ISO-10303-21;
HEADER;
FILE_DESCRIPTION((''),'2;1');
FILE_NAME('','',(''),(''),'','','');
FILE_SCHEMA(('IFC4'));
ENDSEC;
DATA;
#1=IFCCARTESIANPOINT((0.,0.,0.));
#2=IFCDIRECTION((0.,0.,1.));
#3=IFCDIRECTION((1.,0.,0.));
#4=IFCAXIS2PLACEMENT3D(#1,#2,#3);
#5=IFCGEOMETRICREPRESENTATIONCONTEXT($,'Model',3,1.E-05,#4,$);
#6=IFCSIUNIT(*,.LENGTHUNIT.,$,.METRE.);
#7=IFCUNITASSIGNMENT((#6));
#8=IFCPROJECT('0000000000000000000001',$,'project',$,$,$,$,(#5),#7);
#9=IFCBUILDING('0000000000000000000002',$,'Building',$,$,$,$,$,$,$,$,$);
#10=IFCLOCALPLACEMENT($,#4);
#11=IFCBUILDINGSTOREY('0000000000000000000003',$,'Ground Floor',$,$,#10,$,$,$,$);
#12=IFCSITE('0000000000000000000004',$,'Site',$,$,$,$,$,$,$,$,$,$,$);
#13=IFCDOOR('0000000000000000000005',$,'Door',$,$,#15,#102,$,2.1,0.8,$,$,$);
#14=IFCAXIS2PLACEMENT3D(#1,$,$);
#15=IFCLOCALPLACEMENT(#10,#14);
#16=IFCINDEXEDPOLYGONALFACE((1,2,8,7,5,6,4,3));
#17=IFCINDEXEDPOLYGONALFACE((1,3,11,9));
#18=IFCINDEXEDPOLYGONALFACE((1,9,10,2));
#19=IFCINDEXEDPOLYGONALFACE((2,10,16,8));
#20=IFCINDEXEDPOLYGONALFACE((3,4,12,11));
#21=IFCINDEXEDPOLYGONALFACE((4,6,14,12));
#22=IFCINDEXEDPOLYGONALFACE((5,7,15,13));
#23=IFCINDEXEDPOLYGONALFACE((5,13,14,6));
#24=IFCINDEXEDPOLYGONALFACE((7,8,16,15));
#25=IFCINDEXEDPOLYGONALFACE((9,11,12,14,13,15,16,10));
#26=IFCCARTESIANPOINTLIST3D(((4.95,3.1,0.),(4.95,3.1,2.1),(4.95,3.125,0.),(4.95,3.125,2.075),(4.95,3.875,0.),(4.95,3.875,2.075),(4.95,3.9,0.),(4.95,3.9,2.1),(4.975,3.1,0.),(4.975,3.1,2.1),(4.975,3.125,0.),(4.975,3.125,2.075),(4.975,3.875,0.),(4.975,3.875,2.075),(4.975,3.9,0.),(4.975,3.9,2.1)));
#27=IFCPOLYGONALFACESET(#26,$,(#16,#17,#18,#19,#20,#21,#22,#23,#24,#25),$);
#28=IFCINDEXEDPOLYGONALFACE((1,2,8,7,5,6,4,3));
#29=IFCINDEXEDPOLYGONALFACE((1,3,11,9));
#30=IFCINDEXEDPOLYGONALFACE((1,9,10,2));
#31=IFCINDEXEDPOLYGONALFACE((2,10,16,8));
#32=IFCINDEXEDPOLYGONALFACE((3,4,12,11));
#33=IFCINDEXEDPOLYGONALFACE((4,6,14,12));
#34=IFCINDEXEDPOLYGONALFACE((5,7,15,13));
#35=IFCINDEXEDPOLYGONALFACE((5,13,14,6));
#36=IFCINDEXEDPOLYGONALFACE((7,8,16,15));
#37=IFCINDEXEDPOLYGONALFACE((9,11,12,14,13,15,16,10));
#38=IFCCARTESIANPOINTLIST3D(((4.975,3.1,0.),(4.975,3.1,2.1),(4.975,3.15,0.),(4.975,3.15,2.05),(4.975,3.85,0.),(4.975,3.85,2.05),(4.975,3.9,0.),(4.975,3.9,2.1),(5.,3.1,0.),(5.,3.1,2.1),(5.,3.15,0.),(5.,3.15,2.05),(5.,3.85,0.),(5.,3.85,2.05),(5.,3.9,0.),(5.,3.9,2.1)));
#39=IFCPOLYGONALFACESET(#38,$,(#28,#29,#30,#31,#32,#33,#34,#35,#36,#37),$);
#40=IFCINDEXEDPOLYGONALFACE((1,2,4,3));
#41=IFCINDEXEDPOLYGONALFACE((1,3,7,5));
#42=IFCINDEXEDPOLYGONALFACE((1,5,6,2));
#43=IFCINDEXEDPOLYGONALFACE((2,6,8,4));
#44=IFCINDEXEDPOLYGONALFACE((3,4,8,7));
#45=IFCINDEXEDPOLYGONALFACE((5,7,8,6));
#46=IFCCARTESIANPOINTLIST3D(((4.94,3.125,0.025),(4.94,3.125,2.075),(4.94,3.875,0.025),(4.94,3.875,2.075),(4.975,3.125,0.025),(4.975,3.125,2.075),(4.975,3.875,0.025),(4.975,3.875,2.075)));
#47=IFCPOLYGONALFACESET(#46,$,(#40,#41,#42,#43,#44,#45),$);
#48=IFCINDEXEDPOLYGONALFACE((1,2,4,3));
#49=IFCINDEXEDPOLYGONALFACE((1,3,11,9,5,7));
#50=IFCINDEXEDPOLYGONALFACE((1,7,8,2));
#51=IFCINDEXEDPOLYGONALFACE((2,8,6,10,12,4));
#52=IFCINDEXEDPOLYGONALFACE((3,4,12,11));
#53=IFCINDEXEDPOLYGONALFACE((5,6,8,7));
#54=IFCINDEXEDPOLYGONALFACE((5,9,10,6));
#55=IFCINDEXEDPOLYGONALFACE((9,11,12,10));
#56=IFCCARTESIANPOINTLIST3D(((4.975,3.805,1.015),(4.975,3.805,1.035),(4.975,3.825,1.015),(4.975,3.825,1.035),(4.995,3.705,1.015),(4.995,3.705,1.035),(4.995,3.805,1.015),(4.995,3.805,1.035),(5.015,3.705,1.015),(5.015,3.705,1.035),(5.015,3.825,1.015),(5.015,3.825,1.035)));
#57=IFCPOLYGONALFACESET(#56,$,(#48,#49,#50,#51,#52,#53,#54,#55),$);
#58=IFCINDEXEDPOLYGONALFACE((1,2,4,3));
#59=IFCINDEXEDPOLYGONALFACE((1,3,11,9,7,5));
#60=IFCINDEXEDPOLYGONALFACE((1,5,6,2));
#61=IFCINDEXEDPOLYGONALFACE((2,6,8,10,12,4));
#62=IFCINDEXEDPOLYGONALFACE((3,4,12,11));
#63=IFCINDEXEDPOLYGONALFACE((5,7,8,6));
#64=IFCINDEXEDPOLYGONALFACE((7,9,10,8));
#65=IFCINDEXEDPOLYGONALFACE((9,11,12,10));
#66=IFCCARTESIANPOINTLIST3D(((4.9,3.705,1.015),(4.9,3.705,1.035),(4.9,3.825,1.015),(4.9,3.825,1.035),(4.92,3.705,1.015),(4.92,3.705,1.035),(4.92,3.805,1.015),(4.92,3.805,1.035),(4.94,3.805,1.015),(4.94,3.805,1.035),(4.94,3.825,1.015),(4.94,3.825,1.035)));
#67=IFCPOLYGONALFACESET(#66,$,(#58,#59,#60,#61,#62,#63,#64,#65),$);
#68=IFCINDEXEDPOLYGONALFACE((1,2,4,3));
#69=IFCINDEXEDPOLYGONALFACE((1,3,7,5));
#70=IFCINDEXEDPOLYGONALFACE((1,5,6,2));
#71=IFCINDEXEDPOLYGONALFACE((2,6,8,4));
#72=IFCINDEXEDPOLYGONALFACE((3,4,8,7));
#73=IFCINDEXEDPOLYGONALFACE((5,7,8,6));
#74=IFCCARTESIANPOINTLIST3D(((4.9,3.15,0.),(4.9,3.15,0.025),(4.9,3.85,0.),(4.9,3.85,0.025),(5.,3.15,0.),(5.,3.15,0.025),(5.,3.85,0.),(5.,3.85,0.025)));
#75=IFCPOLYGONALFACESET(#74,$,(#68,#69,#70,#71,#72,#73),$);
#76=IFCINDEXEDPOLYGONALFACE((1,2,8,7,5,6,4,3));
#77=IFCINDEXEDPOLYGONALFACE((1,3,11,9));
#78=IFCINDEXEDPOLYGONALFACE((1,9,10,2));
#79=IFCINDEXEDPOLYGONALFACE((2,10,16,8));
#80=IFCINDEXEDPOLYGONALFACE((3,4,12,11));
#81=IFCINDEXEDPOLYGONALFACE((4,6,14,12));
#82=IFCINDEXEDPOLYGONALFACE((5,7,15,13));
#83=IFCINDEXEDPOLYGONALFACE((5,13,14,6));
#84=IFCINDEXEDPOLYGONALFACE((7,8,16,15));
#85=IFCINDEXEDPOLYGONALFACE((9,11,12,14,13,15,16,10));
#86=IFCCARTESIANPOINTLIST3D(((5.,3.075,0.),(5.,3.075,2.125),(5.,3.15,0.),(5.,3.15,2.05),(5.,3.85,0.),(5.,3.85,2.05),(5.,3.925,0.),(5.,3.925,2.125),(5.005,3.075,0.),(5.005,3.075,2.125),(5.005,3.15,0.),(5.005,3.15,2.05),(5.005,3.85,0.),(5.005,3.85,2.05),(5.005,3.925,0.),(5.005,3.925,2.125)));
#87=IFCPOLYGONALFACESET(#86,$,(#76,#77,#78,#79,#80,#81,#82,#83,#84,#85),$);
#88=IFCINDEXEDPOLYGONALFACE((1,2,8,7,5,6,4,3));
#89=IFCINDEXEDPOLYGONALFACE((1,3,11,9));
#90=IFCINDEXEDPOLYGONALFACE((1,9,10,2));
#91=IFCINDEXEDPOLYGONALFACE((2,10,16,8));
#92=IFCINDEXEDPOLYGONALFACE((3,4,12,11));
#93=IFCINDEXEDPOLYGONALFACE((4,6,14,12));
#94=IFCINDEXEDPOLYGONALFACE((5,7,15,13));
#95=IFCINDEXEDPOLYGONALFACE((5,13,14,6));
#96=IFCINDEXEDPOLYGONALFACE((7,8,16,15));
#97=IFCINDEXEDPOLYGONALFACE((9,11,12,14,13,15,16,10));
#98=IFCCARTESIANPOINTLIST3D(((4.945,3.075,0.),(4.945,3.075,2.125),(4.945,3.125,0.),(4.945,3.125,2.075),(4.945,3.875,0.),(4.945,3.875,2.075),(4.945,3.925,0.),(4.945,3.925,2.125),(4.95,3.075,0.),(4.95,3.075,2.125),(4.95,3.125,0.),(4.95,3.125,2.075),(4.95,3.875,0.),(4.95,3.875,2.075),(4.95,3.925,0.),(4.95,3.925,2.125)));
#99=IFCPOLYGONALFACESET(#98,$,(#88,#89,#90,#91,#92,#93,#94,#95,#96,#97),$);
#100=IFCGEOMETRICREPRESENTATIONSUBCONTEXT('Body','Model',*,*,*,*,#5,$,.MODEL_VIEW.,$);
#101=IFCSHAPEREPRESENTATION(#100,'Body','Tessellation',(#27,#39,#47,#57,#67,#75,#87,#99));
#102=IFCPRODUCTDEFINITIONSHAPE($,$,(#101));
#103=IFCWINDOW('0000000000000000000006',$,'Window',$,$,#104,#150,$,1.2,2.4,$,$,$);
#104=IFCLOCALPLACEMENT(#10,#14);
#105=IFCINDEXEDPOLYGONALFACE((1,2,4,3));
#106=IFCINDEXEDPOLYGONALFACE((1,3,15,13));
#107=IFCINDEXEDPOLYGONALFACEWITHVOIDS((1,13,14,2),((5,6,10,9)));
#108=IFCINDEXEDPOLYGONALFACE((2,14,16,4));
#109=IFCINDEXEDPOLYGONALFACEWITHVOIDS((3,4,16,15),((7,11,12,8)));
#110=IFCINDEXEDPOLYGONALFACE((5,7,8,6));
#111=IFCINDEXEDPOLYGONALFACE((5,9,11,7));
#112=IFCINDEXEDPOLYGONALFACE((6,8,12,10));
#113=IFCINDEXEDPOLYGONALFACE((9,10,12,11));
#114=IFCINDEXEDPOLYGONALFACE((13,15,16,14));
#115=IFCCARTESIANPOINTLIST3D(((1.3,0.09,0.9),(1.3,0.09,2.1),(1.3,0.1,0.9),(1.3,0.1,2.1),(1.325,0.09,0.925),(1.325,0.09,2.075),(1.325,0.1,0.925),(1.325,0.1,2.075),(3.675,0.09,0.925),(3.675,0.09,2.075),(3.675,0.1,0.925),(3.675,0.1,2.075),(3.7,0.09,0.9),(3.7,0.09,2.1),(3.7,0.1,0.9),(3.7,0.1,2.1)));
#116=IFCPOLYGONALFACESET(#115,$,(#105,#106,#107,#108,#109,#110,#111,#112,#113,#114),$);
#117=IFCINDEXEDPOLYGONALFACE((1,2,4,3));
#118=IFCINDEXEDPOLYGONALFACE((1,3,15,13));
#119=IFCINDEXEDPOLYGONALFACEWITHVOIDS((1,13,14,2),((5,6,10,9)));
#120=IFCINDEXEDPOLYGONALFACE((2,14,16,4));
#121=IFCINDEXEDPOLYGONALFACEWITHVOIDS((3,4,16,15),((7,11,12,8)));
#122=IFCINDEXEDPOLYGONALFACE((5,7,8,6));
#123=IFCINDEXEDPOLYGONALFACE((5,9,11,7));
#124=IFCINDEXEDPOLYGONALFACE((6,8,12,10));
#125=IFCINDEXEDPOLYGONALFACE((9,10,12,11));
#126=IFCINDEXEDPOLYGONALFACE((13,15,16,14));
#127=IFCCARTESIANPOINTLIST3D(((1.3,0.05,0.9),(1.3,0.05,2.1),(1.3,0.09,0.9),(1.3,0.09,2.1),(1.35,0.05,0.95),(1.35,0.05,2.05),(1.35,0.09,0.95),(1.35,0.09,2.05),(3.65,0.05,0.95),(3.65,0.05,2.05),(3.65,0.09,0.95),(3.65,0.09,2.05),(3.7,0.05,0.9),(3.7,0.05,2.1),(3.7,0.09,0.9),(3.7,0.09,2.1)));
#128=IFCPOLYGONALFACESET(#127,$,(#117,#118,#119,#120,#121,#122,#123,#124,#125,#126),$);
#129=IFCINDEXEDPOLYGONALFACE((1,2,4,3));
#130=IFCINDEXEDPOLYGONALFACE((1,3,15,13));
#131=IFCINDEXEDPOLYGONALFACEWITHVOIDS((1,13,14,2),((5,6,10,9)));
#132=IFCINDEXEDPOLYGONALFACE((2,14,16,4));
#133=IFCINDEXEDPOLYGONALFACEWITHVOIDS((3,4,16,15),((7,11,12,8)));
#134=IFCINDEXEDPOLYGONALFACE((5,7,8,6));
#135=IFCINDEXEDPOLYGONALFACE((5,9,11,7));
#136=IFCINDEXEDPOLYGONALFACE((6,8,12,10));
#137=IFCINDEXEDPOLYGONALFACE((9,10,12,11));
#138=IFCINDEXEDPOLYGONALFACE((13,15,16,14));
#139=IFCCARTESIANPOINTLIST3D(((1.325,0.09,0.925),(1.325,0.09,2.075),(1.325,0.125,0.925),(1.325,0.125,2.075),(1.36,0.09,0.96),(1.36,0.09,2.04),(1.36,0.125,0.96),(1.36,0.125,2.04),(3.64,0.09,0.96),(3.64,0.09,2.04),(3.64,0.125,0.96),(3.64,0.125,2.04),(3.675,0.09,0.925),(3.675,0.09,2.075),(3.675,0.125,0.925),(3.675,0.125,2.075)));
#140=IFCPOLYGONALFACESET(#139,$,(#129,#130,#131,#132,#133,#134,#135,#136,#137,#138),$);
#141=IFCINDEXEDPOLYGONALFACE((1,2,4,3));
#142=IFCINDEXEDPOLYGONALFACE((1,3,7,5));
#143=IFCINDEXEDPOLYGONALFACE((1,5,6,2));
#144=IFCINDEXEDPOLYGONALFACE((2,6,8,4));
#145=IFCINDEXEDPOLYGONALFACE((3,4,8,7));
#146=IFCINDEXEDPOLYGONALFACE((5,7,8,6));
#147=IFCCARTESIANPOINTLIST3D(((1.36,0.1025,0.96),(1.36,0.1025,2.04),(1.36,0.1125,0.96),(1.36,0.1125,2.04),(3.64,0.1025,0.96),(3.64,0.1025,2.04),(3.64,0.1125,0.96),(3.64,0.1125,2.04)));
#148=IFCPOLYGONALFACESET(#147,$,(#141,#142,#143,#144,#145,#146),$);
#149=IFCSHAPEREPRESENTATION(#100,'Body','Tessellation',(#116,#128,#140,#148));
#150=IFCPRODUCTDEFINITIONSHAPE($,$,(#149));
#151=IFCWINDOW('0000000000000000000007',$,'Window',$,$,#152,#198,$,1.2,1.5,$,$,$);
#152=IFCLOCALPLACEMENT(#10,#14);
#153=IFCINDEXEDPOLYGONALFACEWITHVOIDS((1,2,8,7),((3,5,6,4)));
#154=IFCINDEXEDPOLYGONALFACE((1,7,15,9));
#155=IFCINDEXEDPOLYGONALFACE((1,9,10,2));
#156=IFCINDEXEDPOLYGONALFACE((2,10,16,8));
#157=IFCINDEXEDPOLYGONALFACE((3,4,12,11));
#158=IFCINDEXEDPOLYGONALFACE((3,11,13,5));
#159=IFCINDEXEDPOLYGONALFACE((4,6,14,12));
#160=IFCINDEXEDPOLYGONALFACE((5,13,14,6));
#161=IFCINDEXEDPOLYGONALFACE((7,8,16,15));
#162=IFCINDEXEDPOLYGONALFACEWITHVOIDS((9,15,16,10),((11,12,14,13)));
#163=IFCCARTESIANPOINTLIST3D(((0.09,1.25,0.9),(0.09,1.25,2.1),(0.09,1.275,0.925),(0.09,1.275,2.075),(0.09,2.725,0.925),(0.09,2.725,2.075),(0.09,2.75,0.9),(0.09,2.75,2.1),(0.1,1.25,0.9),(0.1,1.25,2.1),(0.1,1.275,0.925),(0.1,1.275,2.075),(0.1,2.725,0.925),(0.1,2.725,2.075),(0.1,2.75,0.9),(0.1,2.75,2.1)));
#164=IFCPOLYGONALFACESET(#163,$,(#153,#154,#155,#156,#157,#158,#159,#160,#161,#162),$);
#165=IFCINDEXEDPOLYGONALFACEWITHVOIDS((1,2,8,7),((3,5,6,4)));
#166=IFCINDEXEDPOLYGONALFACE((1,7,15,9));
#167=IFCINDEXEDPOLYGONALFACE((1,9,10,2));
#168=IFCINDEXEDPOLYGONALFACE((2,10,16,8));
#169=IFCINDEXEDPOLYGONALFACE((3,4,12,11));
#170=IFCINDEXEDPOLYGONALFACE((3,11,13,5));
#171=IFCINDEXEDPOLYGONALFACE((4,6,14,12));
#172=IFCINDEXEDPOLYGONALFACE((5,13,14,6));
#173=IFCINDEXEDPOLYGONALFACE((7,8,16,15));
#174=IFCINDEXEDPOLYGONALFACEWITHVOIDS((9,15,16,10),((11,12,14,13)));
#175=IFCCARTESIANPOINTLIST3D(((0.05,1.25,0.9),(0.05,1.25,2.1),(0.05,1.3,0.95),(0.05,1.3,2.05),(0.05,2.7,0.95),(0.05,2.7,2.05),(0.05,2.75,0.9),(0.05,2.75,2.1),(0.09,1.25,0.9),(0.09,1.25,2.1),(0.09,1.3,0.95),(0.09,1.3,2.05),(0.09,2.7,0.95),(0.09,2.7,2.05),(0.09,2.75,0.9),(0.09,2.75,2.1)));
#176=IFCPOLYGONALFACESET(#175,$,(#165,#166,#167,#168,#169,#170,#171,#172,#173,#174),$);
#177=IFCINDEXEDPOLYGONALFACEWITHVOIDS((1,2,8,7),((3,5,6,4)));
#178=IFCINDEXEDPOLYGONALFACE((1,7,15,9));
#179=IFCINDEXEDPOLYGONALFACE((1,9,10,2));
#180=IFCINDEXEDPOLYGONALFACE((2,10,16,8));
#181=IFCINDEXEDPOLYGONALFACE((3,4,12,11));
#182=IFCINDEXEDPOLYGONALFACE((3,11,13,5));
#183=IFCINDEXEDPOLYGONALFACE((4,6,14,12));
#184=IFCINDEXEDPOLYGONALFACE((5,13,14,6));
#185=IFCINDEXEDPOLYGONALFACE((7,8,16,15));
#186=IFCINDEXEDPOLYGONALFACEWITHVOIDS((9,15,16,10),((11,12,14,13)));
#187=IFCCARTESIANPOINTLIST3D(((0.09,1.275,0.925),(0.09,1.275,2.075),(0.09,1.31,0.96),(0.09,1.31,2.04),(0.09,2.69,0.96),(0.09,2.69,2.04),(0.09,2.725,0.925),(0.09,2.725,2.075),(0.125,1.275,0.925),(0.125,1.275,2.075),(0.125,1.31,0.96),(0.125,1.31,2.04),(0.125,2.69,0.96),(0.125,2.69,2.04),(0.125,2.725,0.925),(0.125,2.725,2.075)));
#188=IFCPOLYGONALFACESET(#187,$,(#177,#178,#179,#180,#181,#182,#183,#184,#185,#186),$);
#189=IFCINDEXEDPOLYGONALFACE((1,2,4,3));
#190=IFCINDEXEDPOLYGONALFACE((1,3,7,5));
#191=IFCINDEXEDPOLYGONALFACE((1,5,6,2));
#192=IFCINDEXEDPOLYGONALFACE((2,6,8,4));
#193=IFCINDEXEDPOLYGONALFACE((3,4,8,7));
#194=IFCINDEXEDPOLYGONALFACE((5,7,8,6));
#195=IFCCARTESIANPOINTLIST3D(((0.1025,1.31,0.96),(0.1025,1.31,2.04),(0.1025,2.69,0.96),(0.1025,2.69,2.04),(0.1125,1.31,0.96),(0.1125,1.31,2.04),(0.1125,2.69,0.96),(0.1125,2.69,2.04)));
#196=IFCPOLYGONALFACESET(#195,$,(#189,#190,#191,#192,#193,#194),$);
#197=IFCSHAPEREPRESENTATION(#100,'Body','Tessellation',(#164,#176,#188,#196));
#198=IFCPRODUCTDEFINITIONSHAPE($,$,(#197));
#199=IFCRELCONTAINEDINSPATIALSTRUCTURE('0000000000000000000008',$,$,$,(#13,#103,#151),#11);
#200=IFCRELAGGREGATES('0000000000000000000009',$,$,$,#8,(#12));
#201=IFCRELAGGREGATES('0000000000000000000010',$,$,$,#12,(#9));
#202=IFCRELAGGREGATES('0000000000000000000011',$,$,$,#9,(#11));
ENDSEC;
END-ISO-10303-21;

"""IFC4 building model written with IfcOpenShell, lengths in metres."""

from ifc_helpers import new_model, si_unit, frame, origin_with_axes, place, context, subcontext, project, spatial, line, indexed_curve, outline, extrude, element, save


model = new_model("IFC4")

# Units and contexts
model_context = context("Model", 3, precision=1e-05, world=origin_with_axes())
body_context = subcontext(model_context, "Body", "Model", "MODEL_VIEW")
ifc_project = project(units=[si_unit("LENGTHUNIT", "METRE")], contexts=[model_context])

# Site, building, storey
site = spatial("IfcSite", under=ifc_project, Name="Site")
building = spatial("IfcBuilding", under=site, Name="Building")
storey_placement = place(None, origin_with_axes())
storey = spatial("IfcBuildingStorey", under=building, at=storey_placement, Name="Ground Floor")

# Door
door_1_placement = place(storey_placement, frame((5.0, 3.1, 0.0), z_axis=(0.0, 0.0, 1.0), x_axis=(0.0, 1.0, 0.0)))
element("IfcDoor", 1, at=door_1_placement, inside=storey, Name="Door", OverallHeight=2.1, OverallWidth=0.8, context=body_context, shape_type="SweptSolid", body=[
    extrude(outline(indexed_curve([(0.0, 0.0), (0.0, 2.1), (0.8, 2.1), (0.8, 0.0), (0.775, 0.0), (0.775, 2.075), (0.025, 2.075), (0.025, 0.0)], segments=[line(1, 2, 3, 4, 5, 6, 7, 8, 1)])), frame((0.0, 0.025, 0.0), z_axis=(0.0, -1.0, 0.0), x_axis=(1.0, 0.0, 0.0)), (0.0, 0.0, -1.0), 0.025),
    extrude(outline(indexed_curve([(0.0, 0.0), (0.0, 2.1), (0.8, 2.1), (0.8, 0.0), (0.75, 0.0), (0.75, 2.05), (0.05, 2.05), (0.05, 0.0)], segments=[line(1, 2, 3, 4, 5, 6, 7, 8, 1)])), frame((0.0, 0.0, 0.0), z_axis=(0.0, -1.0, 0.0), x_axis=(1.0, 0.0, 0.0)), (0.0, 0.0, -1.0), 0.025),
    extrude(outline(indexed_curve([(0.0, 0.0), (0.75, 0.0), (0.75, 0.035), (0.0, 0.035)], segments=[line(1, 2, 3, 4, 1)])), frame((0.025, 0.025, 0.025), z_axis=(0.0, 0.0, 1.0), x_axis=(1.0, 0.0, 0.0)), (0.0, 0.0, 1.0), 2.05),
    extrude(outline(indexed_curve([(0.0, 0.0), (0.0, -0.04), (-0.12, -0.04), (-0.12, -0.02), (-0.02, -0.02), (-0.02, 0.0)], segments=[line(1, 2, 3, 4, 5, 6, 1)])), frame((0.725, 0.025, 1.015), z_axis=(0.0, 0.0, 1.0), x_axis=(1.0, 0.0, 0.0)), (0.0, 0.0, 1.0), 0.02),
    extrude(outline(indexed_curve([(0.0, 0.0), (0.0, 0.04), (-0.12, 0.04), (-0.12, 0.02), (-0.02, 0.02), (-0.02, 0.0)], segments=[line(1, 2, 3, 4, 5, 6, 1)])), frame((0.725, 0.06, 1.015), z_axis=(0.0, 0.0, 1.0), x_axis=(1.0, 0.0, 0.0)), (0.0, 0.0, 1.0), 0.02),
    extrude(outline(indexed_curve([(0.0, 0.0), (0.7, 0.0), (0.7, 0.1), (0.0, 0.1)], segments=[line(1, 2, 3, 4, 1)])), frame((0.05, 0.0, 0.0), z_axis=(0.0, 0.0, 1.0), x_axis=(1.0, 0.0, 0.0)), (0.0, 0.0, 1.0), 0.025),
    extrude(outline(indexed_curve([(0.0, 0.0), (0.0, 2.125), (0.85, 2.125), (0.85, 0.0), (0.775, 0.0), (0.775, 2.05), (0.075, 2.05), (0.075, 0.0)], segments=[line(1, 2, 3, 4, 5, 6, 7, 8, 1)])), frame((-0.025, -0.005, 0.0), z_axis=(0.0, -1.0, 0.0), x_axis=(1.0, 0.0, 0.0)), (0.0, 0.0, -1.0), 0.005),
    extrude(outline(indexed_curve([(0.0, 0.0), (0.0, 2.125), (0.85, 2.125), (0.85, 0.0), (0.8, 0.0), (0.8, 2.075), (0.05, 2.075), (0.05, 0.0)], segments=[line(1, 2, 3, 4, 5, 6, 7, 8, 1)])), frame((-0.025, 0.05, 0.0), z_axis=(0.0, -1.0, 0.0), x_axis=(1.0, 0.0, 0.0)), (0.0, 0.0, -1.0), 0.005),
])

# Windows
window_1_placement = place(storey_placement, frame((1.3, 0.0, 0.9), z_axis=(0.0, 0.0, 1.0), x_axis=(1.0, 0.0, 0.0)))
element("IfcWindow", 2, at=window_1_placement, inside=storey, Name="Window", OverallHeight=1.2, OverallWidth=2.4, context=body_context, shape_type="SweptSolid", body=[
    extrude(outline(indexed_curve([(0.0, 0.0), (2.4, 0.0), (2.4, 1.2), (0.0, 1.2)], segments=[line(1, 2, 3, 4, 1)]), holes=[indexed_curve([(0.025, 0.025), (2.375, 0.025), (2.375, 1.175), (0.025, 1.175)], segments=[line(1, 2, 3, 4, 1)])]), frame((0.0, 0.09, 0.0), z_axis=(0.0, -1.0, 0.0), x_axis=(1.0, 0.0, 0.0)), (0.0, 0.0, -1.0), 0.01),
    extrude(outline(indexed_curve([(0.0, 0.0), (2.4, 0.0), (2.4, 1.2), (0.0, 1.2)], segments=[line(1, 2, 3, 4, 1)]), holes=[indexed_curve([(0.05, 0.05), (2.35, 0.05), (2.35, 1.15), (0.05, 1.15)], segments=[line(1, 2, 3, 4, 1)])]), frame((0.0, 0.05, 0.0), z_axis=(0.0, -1.0, 0.0), x_axis=(1.0, 0.0, 0.0)), (0.0, 0.0, -1.0), 0.04),
    extrude(outline(indexed_curve([(0.0, 0.0), (2.35, 0.0), (2.35, 1.15), (0.0, 1.15)], segments=[line(1, 2, 3, 4, 1)]), holes=[indexed_curve([(0.035, 0.035), (2.315, 0.035), (2.315, 1.115), (0.035, 1.115)], segments=[line(1, 2, 3, 4, 1)])]), frame((0.025, 0.09, 0.025), z_axis=(0.0, -1.0, 0.0), x_axis=(1.0, 0.0, 0.0)), (0.0, 0.0, -1.0), 0.035),
    extrude(outline(indexed_curve([(0.035, 0.035), (2.315, 0.035), (2.315, 1.115), (0.035, 1.115)], segments=[line(1, 2, 3, 4, 1)])), frame((0.025, 0.1025, 0.025), z_axis=(0.0, -1.0, 0.0), x_axis=(1.0, 0.0, 0.0)), (0.0, 0.0, -1.0), 0.01),
])
window_2_placement = place(storey_placement, frame((0.0, 2.75, 0.9), z_axis=(0.0, 0.0, 1.0), x_axis=(0.0, -1.0, 0.0)))
element("IfcWindow", 3, at=window_2_placement, inside=storey, Name="Window", OverallHeight=1.2, OverallWidth=1.5, context=body_context, shape_type="SweptSolid", body=[
    extrude(outline(indexed_curve([(0.0, 0.0), (1.5, 0.0), (1.5, 1.2), (0.0, 1.2)], segments=[line(1, 2, 3, 4, 1)]), holes=[indexed_curve([(0.025, 0.025), (1.475, 0.025), (1.475, 1.175), (0.025, 1.175)], segments=[line(1, 2, 3, 4, 1)])]), frame((0.0, 0.09, 0.0), z_axis=(0.0, -1.0, 0.0), x_axis=(1.0, 0.0, 0.0)), (0.0, 0.0, -1.0), 0.01),
    extrude(outline(indexed_curve([(0.0, 0.0), (1.5, 0.0), (1.5, 1.2), (0.0, 1.2)], segments=[line(1, 2, 3, 4, 1)]), holes=[indexed_curve([(0.05, 0.05), (1.45, 0.05), (1.45, 1.15), (0.05, 1.15)], segments=[line(1, 2, 3, 4, 1)])]), frame((0.0, 0.05, 0.0), z_axis=(0.0, -1.0, 0.0), x_axis=(1.0, 0.0, 0.0)), (0.0, 0.0, -1.0), 0.04),
    extrude(outline(indexed_curve([(0.0, 0.0), (1.45, 0.0), (1.45, 1.15), (0.0, 1.15)], segments=[line(1, 2, 3, 4, 1)]), holes=[indexed_curve([(0.035, 0.035), (1.415, 0.035), (1.415, 1.115), (0.035, 1.115)], segments=[line(1, 2, 3, 4, 1)])]), frame((0.025, 0.09, 0.025), z_axis=(0.0, -1.0, 0.0), x_axis=(1.0, 0.0, 0.0)), (0.0, 0.0, -1.0), 0.035),
    extrude(outline(indexed_curve([(0.035, 0.035), (1.415, 0.035), (1.415, 1.115), (0.035, 1.115)], segments=[line(1, 2, 3, 4, 1)])), frame((0.025, 0.1025, 0.025), z_axis=(0.0, -1.0, 0.0), x_axis=(1.0, 0.0, 0.0)), (0.0, 0.0, -1.0), 0.01),
])

save(model, "model.ifc")
